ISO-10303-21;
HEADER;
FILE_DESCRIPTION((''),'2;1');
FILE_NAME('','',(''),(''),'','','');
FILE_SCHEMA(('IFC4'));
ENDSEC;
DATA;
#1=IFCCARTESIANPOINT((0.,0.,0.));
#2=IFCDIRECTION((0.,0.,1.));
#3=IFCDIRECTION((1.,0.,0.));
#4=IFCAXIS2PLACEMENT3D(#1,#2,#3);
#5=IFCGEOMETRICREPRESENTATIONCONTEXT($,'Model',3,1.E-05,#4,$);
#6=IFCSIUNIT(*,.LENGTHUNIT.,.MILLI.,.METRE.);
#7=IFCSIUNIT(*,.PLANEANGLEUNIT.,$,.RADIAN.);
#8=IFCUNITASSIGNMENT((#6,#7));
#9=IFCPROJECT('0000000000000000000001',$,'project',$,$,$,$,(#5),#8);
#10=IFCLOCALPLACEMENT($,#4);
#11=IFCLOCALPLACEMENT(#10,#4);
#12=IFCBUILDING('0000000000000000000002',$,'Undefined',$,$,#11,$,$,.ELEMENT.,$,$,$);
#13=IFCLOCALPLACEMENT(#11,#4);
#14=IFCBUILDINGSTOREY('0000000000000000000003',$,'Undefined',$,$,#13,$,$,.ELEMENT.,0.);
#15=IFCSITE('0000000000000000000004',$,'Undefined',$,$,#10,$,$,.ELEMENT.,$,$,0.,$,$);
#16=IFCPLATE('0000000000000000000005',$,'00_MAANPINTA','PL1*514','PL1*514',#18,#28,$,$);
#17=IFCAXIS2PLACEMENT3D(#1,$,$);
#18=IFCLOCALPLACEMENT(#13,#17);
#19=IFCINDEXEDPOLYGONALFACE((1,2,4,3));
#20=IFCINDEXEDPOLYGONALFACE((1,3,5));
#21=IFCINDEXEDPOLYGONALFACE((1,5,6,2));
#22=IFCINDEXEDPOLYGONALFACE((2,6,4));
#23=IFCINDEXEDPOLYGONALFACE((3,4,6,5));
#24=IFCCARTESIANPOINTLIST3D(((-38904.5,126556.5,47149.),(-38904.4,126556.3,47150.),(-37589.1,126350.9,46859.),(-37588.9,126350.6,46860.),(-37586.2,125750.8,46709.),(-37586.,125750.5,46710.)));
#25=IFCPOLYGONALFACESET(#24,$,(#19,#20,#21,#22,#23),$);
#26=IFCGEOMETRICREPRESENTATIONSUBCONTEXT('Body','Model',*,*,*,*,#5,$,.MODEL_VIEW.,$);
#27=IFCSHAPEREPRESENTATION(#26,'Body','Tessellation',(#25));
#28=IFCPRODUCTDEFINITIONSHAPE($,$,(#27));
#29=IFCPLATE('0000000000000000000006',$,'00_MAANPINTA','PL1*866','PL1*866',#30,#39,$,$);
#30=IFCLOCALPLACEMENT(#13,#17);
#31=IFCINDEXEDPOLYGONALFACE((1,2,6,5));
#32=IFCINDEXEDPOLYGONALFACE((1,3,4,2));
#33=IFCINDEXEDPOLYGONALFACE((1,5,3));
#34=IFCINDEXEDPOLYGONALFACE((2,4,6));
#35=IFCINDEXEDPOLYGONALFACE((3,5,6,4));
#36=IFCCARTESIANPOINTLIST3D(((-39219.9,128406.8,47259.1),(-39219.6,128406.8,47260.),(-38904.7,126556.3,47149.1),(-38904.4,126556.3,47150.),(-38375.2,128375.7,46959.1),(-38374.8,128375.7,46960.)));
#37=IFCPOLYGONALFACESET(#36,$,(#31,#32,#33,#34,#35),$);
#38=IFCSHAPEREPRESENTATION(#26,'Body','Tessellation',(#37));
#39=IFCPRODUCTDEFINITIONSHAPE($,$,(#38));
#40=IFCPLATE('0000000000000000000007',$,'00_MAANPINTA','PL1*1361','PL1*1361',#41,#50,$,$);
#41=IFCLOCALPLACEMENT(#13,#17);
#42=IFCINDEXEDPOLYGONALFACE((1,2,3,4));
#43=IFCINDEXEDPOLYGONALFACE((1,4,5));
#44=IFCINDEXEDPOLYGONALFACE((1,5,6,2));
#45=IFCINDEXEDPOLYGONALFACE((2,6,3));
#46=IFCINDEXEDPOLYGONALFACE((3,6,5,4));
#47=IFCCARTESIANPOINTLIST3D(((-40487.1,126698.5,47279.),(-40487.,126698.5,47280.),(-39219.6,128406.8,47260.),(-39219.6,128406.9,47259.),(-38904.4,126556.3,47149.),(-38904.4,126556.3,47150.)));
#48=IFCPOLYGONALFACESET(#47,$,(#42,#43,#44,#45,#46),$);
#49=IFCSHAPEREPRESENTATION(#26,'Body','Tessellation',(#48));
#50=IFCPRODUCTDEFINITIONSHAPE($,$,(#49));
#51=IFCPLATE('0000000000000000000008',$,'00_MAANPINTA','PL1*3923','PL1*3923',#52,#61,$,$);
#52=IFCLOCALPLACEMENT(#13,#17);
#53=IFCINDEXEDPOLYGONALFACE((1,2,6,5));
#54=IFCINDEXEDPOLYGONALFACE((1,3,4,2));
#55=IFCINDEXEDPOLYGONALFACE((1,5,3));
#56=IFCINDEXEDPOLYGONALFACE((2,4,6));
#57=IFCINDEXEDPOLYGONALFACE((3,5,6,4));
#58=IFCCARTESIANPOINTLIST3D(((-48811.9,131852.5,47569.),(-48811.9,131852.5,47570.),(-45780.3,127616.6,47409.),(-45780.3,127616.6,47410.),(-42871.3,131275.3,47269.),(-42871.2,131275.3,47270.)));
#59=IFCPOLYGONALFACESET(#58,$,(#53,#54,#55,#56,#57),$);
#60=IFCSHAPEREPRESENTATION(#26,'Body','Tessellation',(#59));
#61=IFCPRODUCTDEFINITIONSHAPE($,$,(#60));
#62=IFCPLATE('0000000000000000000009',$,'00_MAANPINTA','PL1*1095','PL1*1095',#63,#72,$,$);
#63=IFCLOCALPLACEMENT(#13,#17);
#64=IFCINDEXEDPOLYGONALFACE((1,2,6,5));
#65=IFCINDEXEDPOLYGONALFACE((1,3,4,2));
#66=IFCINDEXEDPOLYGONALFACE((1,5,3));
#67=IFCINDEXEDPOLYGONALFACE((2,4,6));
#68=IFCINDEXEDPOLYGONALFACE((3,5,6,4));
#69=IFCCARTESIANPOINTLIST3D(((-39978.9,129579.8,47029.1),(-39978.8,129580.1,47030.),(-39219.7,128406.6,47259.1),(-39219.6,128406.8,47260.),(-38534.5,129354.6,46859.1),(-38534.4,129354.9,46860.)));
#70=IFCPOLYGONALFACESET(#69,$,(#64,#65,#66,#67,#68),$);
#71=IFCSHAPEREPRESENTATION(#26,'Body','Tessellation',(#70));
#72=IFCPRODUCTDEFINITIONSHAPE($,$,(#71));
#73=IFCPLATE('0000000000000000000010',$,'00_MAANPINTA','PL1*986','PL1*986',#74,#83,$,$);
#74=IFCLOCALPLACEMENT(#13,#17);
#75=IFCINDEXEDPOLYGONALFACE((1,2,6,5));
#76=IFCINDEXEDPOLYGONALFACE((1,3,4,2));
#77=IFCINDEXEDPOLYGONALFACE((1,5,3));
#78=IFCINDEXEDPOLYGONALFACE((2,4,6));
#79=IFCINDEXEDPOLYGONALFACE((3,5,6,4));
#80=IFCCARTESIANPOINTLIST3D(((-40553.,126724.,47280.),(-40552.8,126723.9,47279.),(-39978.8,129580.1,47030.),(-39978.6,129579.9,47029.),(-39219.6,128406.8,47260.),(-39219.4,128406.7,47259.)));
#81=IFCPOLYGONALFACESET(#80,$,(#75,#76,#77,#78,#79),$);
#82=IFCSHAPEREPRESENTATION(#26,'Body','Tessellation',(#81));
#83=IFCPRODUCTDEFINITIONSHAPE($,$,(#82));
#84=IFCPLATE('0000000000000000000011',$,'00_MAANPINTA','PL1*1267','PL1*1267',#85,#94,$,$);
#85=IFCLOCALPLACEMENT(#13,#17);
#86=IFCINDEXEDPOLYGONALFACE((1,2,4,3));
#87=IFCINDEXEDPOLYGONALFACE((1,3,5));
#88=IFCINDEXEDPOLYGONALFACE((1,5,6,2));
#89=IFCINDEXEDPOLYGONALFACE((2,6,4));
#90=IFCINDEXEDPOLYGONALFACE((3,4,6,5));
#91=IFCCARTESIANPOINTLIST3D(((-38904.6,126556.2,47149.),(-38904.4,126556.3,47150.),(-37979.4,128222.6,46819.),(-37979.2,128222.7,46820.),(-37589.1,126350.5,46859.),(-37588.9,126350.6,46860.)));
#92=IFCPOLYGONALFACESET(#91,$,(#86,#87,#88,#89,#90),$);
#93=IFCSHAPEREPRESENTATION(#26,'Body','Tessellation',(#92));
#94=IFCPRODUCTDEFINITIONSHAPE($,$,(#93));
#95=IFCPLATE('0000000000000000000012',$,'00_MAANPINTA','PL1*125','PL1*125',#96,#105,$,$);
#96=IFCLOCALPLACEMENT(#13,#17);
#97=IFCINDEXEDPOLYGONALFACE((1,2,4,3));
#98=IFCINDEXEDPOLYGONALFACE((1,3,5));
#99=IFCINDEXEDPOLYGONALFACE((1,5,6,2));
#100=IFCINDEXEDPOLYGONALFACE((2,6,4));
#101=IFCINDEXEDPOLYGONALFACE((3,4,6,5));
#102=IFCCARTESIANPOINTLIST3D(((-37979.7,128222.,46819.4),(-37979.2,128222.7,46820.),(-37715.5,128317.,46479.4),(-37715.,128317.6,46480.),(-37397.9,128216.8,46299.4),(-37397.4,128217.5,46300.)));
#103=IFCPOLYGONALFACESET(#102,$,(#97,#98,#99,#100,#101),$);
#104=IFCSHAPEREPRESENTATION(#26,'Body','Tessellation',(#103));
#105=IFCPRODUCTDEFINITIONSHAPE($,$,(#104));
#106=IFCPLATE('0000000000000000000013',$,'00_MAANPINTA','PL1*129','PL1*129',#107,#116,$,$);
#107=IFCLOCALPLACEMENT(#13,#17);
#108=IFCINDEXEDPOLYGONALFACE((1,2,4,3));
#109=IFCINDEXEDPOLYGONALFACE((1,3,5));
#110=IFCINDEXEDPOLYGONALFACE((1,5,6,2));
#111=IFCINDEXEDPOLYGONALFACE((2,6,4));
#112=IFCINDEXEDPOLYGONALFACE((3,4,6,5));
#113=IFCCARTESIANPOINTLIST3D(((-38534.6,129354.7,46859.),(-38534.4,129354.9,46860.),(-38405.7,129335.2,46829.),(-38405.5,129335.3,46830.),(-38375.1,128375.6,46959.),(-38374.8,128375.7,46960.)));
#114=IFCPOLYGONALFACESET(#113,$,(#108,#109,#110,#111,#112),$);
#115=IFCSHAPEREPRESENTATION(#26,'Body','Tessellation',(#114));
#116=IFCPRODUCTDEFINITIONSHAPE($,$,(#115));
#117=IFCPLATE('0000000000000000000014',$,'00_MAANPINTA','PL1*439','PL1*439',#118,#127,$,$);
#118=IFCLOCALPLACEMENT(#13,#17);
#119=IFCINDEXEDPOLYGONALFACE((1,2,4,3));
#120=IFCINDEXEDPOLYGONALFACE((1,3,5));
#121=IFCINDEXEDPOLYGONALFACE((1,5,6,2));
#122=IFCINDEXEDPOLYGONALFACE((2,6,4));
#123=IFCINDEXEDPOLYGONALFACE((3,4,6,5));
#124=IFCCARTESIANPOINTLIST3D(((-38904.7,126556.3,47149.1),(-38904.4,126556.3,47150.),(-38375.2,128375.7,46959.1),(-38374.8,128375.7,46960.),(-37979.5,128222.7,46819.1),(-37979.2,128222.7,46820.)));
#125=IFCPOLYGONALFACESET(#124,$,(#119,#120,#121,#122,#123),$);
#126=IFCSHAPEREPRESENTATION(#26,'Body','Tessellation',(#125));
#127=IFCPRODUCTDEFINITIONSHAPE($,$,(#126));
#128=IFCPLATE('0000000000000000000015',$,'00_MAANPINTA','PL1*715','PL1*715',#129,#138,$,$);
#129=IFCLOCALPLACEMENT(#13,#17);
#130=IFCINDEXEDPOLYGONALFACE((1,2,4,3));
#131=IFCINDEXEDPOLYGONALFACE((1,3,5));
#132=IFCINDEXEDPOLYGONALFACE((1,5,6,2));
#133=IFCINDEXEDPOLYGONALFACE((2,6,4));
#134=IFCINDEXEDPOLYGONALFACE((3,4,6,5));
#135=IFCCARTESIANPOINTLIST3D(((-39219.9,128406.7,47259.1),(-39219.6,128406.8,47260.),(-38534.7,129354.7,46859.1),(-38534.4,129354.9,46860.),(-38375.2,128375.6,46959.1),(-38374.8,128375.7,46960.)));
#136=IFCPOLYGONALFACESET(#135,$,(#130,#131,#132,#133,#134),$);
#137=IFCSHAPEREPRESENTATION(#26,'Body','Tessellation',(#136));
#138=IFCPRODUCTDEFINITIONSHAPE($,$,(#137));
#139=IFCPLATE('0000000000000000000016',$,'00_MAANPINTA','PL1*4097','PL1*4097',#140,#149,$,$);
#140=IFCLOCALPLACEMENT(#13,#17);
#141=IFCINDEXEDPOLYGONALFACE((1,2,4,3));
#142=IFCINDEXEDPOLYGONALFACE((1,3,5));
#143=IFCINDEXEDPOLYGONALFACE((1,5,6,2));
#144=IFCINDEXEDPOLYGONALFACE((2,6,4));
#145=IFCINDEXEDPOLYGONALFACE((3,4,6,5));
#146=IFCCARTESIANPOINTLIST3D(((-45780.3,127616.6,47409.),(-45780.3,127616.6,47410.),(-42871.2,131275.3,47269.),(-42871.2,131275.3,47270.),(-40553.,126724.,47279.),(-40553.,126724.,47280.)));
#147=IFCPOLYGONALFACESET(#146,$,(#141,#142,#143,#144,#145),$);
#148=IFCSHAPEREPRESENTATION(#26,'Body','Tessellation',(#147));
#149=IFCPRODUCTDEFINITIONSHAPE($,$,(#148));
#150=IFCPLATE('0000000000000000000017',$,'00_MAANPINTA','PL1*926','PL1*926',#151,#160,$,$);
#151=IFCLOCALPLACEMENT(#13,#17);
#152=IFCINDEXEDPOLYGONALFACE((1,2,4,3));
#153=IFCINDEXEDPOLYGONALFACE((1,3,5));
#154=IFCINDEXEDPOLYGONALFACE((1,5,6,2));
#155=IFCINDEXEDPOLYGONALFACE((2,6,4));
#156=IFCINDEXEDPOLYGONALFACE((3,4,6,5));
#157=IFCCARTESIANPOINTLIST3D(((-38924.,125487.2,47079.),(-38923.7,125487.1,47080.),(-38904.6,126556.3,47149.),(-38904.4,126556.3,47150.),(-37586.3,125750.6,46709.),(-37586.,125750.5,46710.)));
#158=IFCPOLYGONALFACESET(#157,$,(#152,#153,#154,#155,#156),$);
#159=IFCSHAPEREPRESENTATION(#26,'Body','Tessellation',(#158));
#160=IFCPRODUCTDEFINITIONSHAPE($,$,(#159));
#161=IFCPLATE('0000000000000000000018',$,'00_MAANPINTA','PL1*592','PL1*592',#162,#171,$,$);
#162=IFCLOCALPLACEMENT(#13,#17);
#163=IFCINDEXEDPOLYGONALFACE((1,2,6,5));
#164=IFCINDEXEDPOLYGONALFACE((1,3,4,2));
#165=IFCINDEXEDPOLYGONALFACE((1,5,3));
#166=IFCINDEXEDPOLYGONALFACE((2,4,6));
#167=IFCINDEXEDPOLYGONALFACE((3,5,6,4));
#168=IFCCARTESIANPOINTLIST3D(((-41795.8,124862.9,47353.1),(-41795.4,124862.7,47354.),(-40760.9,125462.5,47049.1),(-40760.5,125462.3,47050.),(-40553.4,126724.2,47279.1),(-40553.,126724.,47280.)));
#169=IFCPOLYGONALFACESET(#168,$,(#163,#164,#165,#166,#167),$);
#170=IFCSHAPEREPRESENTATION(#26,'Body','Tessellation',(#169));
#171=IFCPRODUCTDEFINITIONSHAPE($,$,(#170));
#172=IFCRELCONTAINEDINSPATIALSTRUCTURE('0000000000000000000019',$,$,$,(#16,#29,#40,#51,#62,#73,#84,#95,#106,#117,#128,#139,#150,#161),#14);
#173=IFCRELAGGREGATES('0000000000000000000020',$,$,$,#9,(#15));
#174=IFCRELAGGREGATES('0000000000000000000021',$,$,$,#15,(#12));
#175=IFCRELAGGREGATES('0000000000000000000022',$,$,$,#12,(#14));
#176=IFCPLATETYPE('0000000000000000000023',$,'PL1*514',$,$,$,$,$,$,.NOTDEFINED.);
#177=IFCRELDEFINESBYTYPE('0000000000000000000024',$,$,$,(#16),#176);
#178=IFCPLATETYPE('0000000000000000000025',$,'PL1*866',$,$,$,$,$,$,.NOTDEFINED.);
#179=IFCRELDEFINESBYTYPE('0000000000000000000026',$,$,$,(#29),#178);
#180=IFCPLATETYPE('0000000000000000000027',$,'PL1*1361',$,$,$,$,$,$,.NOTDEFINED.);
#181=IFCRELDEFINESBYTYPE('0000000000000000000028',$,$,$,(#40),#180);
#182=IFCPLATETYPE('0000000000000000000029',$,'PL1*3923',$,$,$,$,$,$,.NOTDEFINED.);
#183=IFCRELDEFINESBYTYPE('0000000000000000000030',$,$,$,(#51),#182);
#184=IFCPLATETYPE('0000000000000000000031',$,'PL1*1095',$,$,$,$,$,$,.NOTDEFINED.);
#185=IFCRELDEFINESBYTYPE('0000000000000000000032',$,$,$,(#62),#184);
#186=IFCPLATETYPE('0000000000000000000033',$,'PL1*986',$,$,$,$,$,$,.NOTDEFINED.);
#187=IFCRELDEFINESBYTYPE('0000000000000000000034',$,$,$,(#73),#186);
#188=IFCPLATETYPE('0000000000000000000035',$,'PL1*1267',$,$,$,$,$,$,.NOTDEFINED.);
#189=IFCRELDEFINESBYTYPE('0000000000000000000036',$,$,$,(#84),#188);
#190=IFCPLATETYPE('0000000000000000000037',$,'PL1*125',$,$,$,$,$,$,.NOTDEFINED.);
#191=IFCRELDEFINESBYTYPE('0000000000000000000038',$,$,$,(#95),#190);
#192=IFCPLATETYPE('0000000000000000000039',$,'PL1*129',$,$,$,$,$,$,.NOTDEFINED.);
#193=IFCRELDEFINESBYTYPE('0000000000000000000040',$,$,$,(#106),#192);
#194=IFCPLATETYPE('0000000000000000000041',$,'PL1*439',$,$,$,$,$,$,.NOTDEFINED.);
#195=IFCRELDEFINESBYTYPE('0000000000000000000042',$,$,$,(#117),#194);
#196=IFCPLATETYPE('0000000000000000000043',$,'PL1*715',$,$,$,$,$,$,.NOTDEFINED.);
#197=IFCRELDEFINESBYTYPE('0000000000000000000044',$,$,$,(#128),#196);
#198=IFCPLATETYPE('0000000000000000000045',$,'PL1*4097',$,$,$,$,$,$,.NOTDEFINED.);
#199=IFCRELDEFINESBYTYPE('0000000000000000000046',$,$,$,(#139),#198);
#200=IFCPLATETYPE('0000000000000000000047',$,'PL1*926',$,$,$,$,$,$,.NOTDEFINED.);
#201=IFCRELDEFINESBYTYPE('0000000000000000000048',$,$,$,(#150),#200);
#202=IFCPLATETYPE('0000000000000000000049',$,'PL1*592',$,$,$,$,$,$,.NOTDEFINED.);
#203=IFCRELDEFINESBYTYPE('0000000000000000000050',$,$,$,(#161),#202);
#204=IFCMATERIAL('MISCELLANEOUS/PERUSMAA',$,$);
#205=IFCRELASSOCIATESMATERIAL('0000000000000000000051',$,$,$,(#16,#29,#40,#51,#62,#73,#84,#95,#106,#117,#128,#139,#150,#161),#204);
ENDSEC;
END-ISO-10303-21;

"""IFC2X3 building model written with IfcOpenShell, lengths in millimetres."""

from ifc_helpers import new_model, si_unit, frame, origin_with_axes, place, context, subcontext, project, spatial, polyline, outline, extrude, material, type_object, element, save


model = new_model("IFC2X3")

# Units and contexts
model_context = context("Model", 3, precision=1e-05, world=origin_with_axes())
body_context = subcontext(model_context, "Body", "Model", "MODEL_VIEW")
ifc_project = project(units=[si_unit("LENGTHUNIT", "METRE", prefix="MILLI"), si_unit("PLANEANGLEUNIT", "RADIAN")], contexts=[model_context])

# Site, building, storey
site_placement = place(None, origin_with_axes())
site = spatial("IfcSite", under=ifc_project, at=site_placement, Name="Undefined", CompositionType="ELEMENT", RefElevation=0.0)
building_placement = place(site_placement, origin_with_axes())
building = spatial("IfcBuilding", under=site, at=building_placement, Name="Undefined", CompositionType="ELEMENT")
storey_placement = place(building_placement, origin_with_axes())
storey = spatial("IfcBuildingStorey", under=building, at=storey_placement, Name="Undefined", CompositionType="ELEMENT", Elevation=0.0)

# Plates
ifc_material = material(Name="MISCELLANEOUS/PERUSMAA")
plate_type_1 = type_object("IfcPlateType", Name="PL1*514", PredefinedType="NOTDEFINED")
plate_1_placement = place(storey_placement, frame((-37589.0, 126350.7, 46859.5), z_axis=(-0.173457, 0.238046, -0.955639), x_axis=(0.004661, -0.970139, -0.242504)))
element("IfcPlate", 1, at=plate_1_placement, inside=storey, type_object=plate_type_1, material=ifc_material, Name="00_MAANPINTA", Description="PL1*514", ObjectType="PL1*514", context=body_context, shape_type="SweptSolid", body=[
    extrude(outline(polyline([(0.0, 0.0), (618.5, 0.0), (-276.0, 1334.4), (0.0, 0.0)])), frame((0.0, 0.0, -0.5), z_axis=(0.0, 0.0, 1.0), x_axis=(1.0, 0.0, 0.0)), (0.0, 0.0, 1.0), 1.0),
])
plate_type_2 = type_object("IfcPlateType", Name="PL1*866", PredefinedType="NOTDEFINED")
plate_2_placement = place(storey_placement, frame((-38904.5, 126556.3, 47149.5), z_axis=(-0.334704, -0.000994, -0.942323), x_axis=(-0.167612, 0.984116, 0.058497)))
element("IfcPlate", 2, at=plate_2_placement, inside=storey, type_object=plate_type_2, material=ifc_material, Name="00_MAANPINTA", Description="PL1*866", ObjectType="PL1*866", context=body_context, shape_type="SweptSolid", body=[
    extrude(outline(polyline([(0.0, 0.0), (1880.5, 0.0), (1690.7, 876.6), (0.0, 0.0)])), frame((0.0, 0.0, -0.5), z_axis=(0.0, 0.0, 1.0), x_axis=(1.0, 0.0, 0.0)), (0.0, 0.0, 1.0), 1.0),
])
plate_type_3 = type_object("IfcPlateType", Name="PL1*1361", PredefinedType="NOTDEFINED")
plate_3_placement = place(storey_placement, frame((-39219.6, 128406.9, 47259.5), z_axis=(-0.077675, 0.045969, -0.995918), x_axis=(0.167612, -0.984116, -0.058497)))
element("IfcPlate", 3, at=plate_3_placement, inside=storey, type_object=plate_type_3, material=ifc_material, Name="00_MAANPINTA", Description="PL1*1361", ObjectType="PL1*1361", context=body_context, shape_type="SweptSolid", body=[
    extrude(outline(polyline([(0.0, 0.0), (1880.5, 0.0), (1467.6, 1540.0), (0.0, 0.0)])), frame((0.0, 0.0, -0.5), z_axis=(0.0, 0.0, 1.0), x_axis=(1.0, 0.0, 0.0)), (0.0, 0.0, 1.0), 1.0),
])
plate_type_4 = type_object("IfcPlateType", Name="PL1*3923", PredefinedType="NOTDEFINED")
plate_4_placement = place(storey_placement, frame((-45780.3, 127616.6, 47409.5), z_axis=(-0.050265, 0.00175, -0.998734), x_axis=(-0.581726, 0.812805, 0.030702)))
element("IfcPlate", 4, at=plate_4_placement, inside=storey, type_object=plate_type_4, material=ifc_material, Name="00_MAANPINTA", Description="PL1*3923", ObjectType="PL1*3923", context=body_context, shape_type="SweptSolid", body=[
    extrude(outline(polyline([(0.0, 0.0), (5211.4, 0.0), (1277.2, 4498.5), (0.0, 0.0)])), frame((0.0, 0.0, -0.5), z_axis=(0.0, 0.0, 1.0), x_axis=(1.0, 0.0, 0.0)), (0.0, 0.0, 1.0), 1.0),
])
plate_type_5 = type_object("IfcPlateType", Name="PL1*1095", PredefinedType="NOTDEFINED")
plate_5_placement = place(storey_placement, frame((-39219.6, 128406.7, 47259.5), z_axis=(-0.155895, -0.286223, -0.945396), x_axis=(-0.536078, 0.8284, -0.162403)))
element("IfcPlate", 5, at=plate_5_placement, inside=storey, type_object=plate_type_5, material=ifc_material, Name="00_MAANPINTA", Description="PL1*1095", ObjectType="PL1*1095", context=body_context, shape_type="SweptSolid", body=[
    extrude(outline(polyline([(0.0, 0.0), (1416.2, 0.0), (483.0, 1138.0), (0.0, 0.0)])), frame((0.0, 0.0, -0.5), z_axis=(0.0, 0.0, 1.0), x_axis=(1.0, 0.0, 0.0)), (0.0, 0.0, 1.0), 1.0),
])
plate_type_6 = type_object("IfcPlateType", Name="PL1*986", PredefinedType="NOTDEFINED")
plate_6_placement = place(storey_placement, frame((-40552.9, 126723.9, 47279.5), z_axis=(0.126108, -0.111636, -0.985715), x_axis=(0.196381, 0.976793, -0.085502)))
element("IfcPlate", 6, at=plate_6_placement, inside=storey, type_object=plate_type_6, material=ifc_material, Name="00_MAANPINTA", Description="PL1*986", ObjectType="PL1*986", context=body_context, shape_type="SweptSolid", body=[
    extrude(outline(polyline([(0.0, 0.0), (2923.9, 0.0), (1907.4, 986.1), (0.0, 0.0)])), frame((0.0, 0.0, -0.5), z_axis=(0.0, 0.0, 1.0), x_axis=(1.0, 0.0, 0.0)), (0.0, 0.0, 1.0), 1.0),
])
plate_type_7 = type_object("IfcPlateType", Name="PL1*1267", PredefinedType="NOTDEFINED")
plate_7_placement = place(storey_placement, frame((-38904.5, 126556.2, 47149.5), z_axis=(-0.224862, -0.067648, -0.972039), x_axis=(0.478298, 0.861468, -0.170598)))
element("IfcPlate", 7, at=plate_7_placement, inside=storey, type_object=plate_type_7, material=ifc_material, Name="00_MAANPINTA", Description="PL1*1267", ObjectType="PL1*1267", context=body_context, shape_type="SweptSolid", body=[
    extrude(outline(polyline([(0.0, 0.0), (1934.4, 0.0), (501.5, 1267.0), (0.0, 0.0)])), frame((0.0, 0.0, -0.5), z_axis=(0.0, 0.0, 1.0), x_axis=(1.0, 0.0, 0.0)), (0.0, 0.0, 1.0), 1.0),
])
plate_type_8 = type_object("IfcPlateType", Name="PL1*125", PredefinedType="NOTDEFINED")
plate_8_placement = place(storey_placement, frame((-37979.4, 128222.4, 46819.7), z_axis=(-0.525406, -0.621023, -0.581618), x_axis=(0.599165, 0.215292, -0.771136)))
element("IfcPlate", 8, at=plate_8_placement, inside=storey, type_object=plate_type_8, material=ifc_material, Name="00_MAANPINTA", Description="PL1*125", ObjectType="PL1*125", context=body_context, shape_type="SweptSolid", body=[
    extrude(outline(polyline([(0.0, 0.0), (440.9, 0.0), (748.5, 220.7), (0.0, 0.0)])), frame((0.0, 0.0, -0.5), z_axis=(0.0, 0.0, 1.0), x_axis=(1.0, 0.0, 0.0)), (0.0, 0.0, 1.0), 1.0),
])
plate_type_9 = type_object("IfcPlateType", Name="PL1*129", PredefinedType="NOTDEFINED")
plate_9_placement = place(storey_placement, frame((-38375.0, 128375.7, 46959.5), z_axis=(-0.244275, -0.137832, -0.95986), x_axis=(-0.159991, 0.98201, -0.100296)))
element("IfcPlate", 9, at=plate_9_placement, inside=storey, type_object=plate_type_9, material=ifc_material, Name="00_MAANPINTA", Description="PL1*129", ObjectType="PL1*129", context=body_context, shape_type="SweptSolid", body=[
    extrude(outline(polyline([(0.0, 0.0), (997.0, 0.0), (960.2, 128.6), (0.0, 0.0)])), frame((0.0, 0.0, -0.5), z_axis=(0.0, 0.0, 1.0), x_axis=(1.0, 0.0, 0.0)), (0.0, 0.0, 1.0), 1.0),
])
plate_type_10 = type_object("IfcPlateType", Name="PL1*439", PredefinedType="NOTDEFINED")
plate_10_placement = place(storey_placement, frame((-38904.5, 126556.3, 47149.5), z_axis=(-0.333977, -0.001232, -0.94258), x_axis=(0.278042, 0.955374, -0.099765)))
element("IfcPlate", 10, at=plate_10_placement, inside=storey, type_object=plate_type_10, material=ifc_material, Name="00_MAANPINTA", Description="PL1*439", ObjectType="PL1*439", context=body_context, shape_type="SweptSolid", body=[
    extrude(outline(polyline([(0.0, 0.0), (1904.5, 0.0), (1882.2, 446.2), (0.0, 0.0)])), frame((0.0, 0.0, -0.5), z_axis=(0.0, 0.0, 1.0), x_axis=(1.0, 0.0, 0.0)), (0.0, 0.0, 1.0), 1.0),
])
plate_type_11 = type_object("IfcPlateType", Name="PL1*715", PredefinedType="NOTDEFINED")
plate_11_placement = place(storey_placement, frame((-38534.5, 129354.8, 46859.5), z_axis=(-0.335791, -0.149689, -0.929966), x_axis=(0.159991, -0.98201, 0.100296)))
element("IfcPlate", 11, at=plate_11_placement, inside=storey, type_object=plate_type_11, material=ifc_material, Name="00_MAANPINTA", Description="PL1*715", ObjectType="PL1*715", context=body_context, shape_type="SweptSolid", body=[
    extrude(outline(polyline([(0.0, 0.0), (997.0, 0.0), (861.4, 886.6), (0.0, 0.0)])), frame((0.0, 0.0, -0.5), z_axis=(0.0, 0.0, 1.0), x_axis=(1.0, 0.0, 0.0)), (0.0, 0.0, 1.0), 1.0),
])
plate_type_12 = type_object("IfcPlateType", Name="PL1*4097", PredefinedType="NOTDEFINED")
plate_12_placement = place(storey_placement, frame((-40553.0, 126724.0, 47279.5), z_axis=(-0.027635, -0.016272, -0.999486), x_axis=(-0.985436, 0.168271, 0.024507)))
element("IfcPlate", 12, at=plate_12_placement, inside=storey, type_object=plate_type_12, material=ifc_material, Name="00_MAANPINTA", Description="PL1*4097", ObjectType="PL1*4097", context=body_context, shape_type="SweptSolid", body=[
    extrude(outline(polyline([(0.0, 0.0), (5304.5, 0.0), (3050.1, 4097.0), (0.0, 0.0)])), frame((0.0, 0.0, -0.5), z_axis=(0.0, 0.0, 1.0), x_axis=(1.0, 0.0, 0.0)), (0.0, 0.0, 1.0), 1.0),
])
plate_type_13 = type_object("IfcPlateType", Name="PL1*926", PredefinedType="NOTDEFINED")
plate_13_placement = place(storey_placement, frame((-38904.5, 126556.3, 47149.5), z_axis=(-0.278339, 0.06777, -0.958089), x_axis=(0.820639, -0.501537, -0.273884)))
element("IfcPlate", 13, at=plate_13_placement, inside=storey, type_object=plate_type_13, material=ifc_material, Name="00_MAANPINTA", Description="PL1*926", ObjectType="PL1*926", context=body_context, shape_type="SweptSolid", body=[
    extrude(outline(polyline([(0.0, 0.0), (1606.5, 0.0), (539.5, 925.9), (0.0, 0.0)])), frame((0.0, 0.0, -0.5), z_axis=(0.0, 0.0, 1.0), x_axis=(1.0, 0.0, 0.0)), (0.0, 0.0, 1.0), 1.0),
])
plate_type_14 = type_object("IfcPlateType", Name="PL1*592", PredefinedType="NOTDEFINED")
plate_14_placement = place(storey_placement, frame((-40553.2, 126724.1, 47279.6), z_axis=(-0.393306, 0.227121, -0.890913), x_axis=(-0.159779, -0.971148, -0.177038)))
element("IfcPlate", 14, at=plate_14_placement, inside=storey, type_object=plate_type_14, material=ifc_material, Name="00_MAANPINTA", Description="PL1*592", ObjectType="PL1*592", context=body_context, shape_type="SweptSolid", body=[
    extrude(outline(polyline([(0.0, 0.0), (1299.2, 0.0), (1993.1, 1020.6), (0.0, 0.0)])), frame((0.0, 0.0, -0.5), z_axis=(0.0, 0.0, 1.0), x_axis=(1.0, 0.0, 0.0)), (0.0, 0.0, 1.0), 1.0),
])

save(model, "model.ifc")
